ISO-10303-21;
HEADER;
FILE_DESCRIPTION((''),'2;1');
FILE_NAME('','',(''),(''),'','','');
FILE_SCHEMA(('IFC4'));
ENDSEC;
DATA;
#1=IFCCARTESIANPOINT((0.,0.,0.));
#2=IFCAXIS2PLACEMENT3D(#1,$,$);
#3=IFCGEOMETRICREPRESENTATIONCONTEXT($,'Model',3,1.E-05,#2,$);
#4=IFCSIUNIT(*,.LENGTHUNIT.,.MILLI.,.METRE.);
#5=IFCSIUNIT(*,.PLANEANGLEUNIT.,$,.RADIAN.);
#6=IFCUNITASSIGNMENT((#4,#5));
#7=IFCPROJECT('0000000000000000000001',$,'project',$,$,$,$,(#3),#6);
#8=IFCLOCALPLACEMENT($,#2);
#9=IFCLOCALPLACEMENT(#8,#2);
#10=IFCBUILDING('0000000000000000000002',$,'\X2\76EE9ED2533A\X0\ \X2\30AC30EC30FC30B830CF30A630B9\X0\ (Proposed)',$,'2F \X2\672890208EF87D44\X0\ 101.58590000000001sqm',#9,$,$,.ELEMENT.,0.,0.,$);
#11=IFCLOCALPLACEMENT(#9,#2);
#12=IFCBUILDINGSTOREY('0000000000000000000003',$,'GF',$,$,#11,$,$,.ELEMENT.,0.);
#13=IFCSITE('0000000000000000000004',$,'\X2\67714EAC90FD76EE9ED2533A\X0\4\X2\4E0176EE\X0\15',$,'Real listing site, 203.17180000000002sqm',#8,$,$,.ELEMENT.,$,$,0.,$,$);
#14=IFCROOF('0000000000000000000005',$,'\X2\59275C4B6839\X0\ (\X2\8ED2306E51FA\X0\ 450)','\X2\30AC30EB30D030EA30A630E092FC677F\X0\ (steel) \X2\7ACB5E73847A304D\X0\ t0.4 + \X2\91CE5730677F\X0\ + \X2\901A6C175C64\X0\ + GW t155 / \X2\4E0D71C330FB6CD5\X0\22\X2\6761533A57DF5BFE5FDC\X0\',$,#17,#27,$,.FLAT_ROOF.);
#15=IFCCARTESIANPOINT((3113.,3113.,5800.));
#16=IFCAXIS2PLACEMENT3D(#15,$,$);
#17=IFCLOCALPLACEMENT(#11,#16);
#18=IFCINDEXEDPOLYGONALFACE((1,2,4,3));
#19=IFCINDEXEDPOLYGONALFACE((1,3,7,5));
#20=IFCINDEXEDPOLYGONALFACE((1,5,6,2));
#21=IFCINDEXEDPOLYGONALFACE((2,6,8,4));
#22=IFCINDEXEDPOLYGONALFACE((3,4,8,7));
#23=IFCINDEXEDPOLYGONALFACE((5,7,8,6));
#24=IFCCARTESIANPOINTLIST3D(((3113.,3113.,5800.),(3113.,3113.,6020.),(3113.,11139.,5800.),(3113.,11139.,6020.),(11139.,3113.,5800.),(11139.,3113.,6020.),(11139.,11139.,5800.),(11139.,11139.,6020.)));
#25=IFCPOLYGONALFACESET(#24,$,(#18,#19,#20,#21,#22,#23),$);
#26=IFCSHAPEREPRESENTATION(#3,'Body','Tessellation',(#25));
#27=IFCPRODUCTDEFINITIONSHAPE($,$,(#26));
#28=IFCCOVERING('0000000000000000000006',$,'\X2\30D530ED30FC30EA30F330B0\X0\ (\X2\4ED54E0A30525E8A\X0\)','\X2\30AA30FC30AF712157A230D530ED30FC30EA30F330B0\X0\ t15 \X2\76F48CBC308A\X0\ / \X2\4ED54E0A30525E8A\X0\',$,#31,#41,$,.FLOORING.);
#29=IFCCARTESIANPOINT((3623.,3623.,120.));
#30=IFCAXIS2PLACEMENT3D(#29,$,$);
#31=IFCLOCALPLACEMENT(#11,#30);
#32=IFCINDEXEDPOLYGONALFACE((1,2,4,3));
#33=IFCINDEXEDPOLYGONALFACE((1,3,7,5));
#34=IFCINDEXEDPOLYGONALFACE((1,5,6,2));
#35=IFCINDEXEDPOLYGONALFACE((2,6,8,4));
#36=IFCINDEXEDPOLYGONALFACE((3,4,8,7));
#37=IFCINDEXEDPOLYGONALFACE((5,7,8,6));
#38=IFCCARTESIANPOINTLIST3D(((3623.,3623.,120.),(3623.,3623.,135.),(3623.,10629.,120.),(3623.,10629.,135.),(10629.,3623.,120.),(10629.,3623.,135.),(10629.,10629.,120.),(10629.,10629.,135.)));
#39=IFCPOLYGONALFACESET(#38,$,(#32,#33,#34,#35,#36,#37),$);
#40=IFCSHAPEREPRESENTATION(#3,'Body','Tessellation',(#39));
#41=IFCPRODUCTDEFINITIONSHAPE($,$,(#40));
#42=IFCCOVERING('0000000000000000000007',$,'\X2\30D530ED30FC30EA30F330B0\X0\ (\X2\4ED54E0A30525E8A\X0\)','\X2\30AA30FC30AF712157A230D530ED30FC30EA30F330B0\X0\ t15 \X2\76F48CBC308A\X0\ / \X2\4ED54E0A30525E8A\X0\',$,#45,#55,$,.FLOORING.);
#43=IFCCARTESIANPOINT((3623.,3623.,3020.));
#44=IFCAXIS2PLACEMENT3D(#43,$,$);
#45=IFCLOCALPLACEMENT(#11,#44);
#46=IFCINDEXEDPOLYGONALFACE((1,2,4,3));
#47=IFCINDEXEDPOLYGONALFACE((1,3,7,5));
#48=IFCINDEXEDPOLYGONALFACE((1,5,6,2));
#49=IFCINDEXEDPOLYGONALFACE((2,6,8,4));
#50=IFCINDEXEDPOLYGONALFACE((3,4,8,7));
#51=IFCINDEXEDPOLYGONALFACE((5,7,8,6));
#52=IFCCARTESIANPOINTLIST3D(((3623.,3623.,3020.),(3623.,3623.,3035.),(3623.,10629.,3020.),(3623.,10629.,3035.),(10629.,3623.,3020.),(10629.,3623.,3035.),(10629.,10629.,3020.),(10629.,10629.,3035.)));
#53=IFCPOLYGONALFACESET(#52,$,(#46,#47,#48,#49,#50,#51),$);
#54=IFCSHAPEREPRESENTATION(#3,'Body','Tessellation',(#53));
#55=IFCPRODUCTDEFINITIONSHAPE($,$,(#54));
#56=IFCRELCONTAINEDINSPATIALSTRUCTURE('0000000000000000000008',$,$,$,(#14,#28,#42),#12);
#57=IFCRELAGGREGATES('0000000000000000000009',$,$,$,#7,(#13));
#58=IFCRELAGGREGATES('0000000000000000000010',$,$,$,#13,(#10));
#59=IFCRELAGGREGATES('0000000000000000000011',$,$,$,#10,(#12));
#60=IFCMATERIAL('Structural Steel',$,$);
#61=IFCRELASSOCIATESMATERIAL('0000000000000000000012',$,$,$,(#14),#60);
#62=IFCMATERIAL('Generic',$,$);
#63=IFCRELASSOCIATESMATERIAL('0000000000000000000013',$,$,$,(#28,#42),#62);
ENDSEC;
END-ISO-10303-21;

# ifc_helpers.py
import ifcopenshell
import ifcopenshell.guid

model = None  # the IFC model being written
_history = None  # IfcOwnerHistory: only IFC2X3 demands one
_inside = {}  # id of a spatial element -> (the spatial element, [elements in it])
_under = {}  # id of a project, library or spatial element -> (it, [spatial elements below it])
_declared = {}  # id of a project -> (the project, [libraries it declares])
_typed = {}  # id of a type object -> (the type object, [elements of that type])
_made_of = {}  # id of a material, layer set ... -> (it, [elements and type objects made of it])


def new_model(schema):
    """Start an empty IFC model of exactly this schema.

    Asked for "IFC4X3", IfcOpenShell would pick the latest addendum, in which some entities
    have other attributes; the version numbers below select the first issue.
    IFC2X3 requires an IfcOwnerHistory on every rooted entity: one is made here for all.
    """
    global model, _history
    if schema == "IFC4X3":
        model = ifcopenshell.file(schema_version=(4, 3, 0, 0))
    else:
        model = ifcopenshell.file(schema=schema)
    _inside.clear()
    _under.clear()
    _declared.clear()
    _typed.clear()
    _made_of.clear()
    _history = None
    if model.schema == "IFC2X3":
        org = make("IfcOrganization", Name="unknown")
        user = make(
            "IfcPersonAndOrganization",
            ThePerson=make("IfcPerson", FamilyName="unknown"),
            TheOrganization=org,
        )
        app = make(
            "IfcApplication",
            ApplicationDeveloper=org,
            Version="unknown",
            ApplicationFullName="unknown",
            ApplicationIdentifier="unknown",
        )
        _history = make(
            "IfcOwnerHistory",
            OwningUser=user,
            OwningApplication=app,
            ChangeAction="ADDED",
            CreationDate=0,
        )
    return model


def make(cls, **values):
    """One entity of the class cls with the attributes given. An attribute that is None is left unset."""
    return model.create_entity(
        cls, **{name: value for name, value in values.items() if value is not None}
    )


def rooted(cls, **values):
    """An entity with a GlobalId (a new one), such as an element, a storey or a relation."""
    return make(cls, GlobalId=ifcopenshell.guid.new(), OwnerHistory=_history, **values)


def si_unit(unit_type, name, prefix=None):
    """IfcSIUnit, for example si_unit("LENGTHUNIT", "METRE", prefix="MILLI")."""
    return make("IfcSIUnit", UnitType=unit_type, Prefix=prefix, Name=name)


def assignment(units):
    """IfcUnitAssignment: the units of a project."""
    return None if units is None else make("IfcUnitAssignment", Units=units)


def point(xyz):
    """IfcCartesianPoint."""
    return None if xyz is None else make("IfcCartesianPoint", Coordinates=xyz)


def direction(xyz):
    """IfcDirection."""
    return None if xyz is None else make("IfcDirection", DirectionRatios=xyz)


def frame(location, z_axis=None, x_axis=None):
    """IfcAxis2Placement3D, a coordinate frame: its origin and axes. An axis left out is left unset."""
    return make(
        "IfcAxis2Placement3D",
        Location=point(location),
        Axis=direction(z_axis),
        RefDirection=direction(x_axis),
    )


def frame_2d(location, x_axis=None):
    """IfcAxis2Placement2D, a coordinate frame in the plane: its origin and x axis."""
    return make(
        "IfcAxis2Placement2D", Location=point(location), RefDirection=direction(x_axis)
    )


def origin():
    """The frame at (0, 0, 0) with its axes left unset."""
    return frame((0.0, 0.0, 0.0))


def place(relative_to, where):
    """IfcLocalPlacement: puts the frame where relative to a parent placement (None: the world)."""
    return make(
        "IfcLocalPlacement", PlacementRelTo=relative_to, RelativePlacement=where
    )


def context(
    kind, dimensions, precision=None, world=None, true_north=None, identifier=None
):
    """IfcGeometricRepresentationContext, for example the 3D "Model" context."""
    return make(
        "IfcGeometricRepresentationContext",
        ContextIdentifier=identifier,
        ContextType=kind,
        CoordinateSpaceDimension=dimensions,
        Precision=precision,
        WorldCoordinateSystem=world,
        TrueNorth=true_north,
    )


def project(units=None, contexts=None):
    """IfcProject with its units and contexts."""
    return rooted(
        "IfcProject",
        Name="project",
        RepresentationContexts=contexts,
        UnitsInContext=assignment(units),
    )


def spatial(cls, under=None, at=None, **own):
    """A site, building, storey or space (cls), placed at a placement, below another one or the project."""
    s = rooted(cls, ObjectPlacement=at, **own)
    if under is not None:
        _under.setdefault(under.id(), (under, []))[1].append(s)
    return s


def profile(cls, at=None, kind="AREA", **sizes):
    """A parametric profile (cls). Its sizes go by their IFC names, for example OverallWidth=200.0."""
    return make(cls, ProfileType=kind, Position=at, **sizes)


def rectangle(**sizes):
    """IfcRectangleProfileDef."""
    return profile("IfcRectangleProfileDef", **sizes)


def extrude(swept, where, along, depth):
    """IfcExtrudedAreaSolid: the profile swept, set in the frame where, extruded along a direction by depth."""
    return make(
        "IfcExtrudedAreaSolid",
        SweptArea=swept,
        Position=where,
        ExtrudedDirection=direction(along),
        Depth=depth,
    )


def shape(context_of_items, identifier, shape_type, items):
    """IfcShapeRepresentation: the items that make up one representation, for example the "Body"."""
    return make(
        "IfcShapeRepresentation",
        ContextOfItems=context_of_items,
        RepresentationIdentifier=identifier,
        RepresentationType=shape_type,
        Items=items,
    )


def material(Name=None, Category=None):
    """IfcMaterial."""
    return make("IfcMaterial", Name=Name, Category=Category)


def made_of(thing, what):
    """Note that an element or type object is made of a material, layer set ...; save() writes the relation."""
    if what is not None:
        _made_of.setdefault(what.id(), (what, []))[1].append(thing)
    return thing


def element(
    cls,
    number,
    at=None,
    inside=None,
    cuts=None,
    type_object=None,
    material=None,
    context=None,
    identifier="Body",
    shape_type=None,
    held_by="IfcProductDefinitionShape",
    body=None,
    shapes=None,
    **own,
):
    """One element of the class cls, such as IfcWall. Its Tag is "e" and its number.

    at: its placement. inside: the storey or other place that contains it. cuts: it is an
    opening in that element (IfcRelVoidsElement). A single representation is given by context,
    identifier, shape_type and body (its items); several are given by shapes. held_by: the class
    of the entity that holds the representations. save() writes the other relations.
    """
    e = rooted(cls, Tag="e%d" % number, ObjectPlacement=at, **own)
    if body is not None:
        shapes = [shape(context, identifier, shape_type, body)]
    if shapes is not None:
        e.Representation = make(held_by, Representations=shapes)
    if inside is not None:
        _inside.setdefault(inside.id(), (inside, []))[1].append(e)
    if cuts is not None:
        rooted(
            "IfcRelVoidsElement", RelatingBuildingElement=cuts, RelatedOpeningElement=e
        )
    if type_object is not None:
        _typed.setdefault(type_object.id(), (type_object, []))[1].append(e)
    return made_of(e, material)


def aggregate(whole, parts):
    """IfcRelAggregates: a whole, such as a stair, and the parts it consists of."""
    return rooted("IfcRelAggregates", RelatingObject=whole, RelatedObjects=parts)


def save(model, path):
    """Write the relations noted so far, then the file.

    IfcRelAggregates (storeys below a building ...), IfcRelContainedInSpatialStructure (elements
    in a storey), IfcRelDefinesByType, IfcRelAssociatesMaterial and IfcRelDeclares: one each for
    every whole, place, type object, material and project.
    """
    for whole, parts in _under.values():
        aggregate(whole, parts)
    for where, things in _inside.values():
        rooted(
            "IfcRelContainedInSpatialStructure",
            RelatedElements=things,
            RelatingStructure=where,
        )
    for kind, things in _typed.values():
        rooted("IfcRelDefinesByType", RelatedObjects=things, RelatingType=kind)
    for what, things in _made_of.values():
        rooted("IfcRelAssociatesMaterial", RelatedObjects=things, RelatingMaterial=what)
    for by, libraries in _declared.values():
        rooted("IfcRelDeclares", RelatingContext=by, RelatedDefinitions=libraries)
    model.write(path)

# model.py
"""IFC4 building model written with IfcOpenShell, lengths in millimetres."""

from ifc_helpers import new_model, si_unit, frame, frame_2d, origin, place, context, project, spatial, rectangle, extrude, material, element, save


model = new_model("IFC4")

# Units and contexts
model_context = context("Model", 3, precision=1e-05, world=origin())
ifc_project = project(units=[si_unit("LENGTHUNIT", "METRE", prefix="MILLI"), si_unit("PLANEANGLEUNIT", "RADIAN")], contexts=[model_context])

# Site, building, storey
site_placement = place(None, origin())
site = spatial("IfcSite", under=ifc_project, at=site_placement, Name="東京都目黒区4丁目15", ObjectType="Real listing site, 203.17180000000002sqm", CompositionType="ELEMENT", RefElevation=0.0)
building_placement = place(site_placement, origin())
building = spatial("IfcBuilding", under=site, at=building_placement, Name="目黒区 ガレージハウス (Proposed)", ObjectType="2F 木造軸組 101.58590000000001sqm", CompositionType="ELEMENT", ElevationOfRefHeight=0.0, ElevationOfTerrain=0.0)
storey_placement = place(building_placement, origin())
storey = spatial("IfcBuildingStorey", under=building, at=storey_placement, Name="GF", CompositionType="ELEMENT", Elevation=0.0)

# Roof
ifc_material_1 = material(Name="Structural Steel")
roof_placement = place(storey_placement, frame((3113.0, 3113.0, 5800.0)))
element("IfcRoof", 1, at=roof_placement, inside=storey, material=ifc_material_1, Name="大屋根 (軒の出 450)", Description="ガルバリウム鋼板 (steel) 立平葺き t0.4 + 野地板 + 通気層 + GW t155 / 不燃・法22条区域対応", PredefinedType="FLAT_ROOF", context=model_context, shape_type="SweptSolid", body=[
    extrude(rectangle(XDim=8026.0, YDim=8026.0, at=frame_2d((4013.0, 4013.0))), frame((3113.0, 3113.0, 5800.0)), (0.0, 0.0, 1.0), 220.0),
])

# Coverings
ifc_material_2 = material(Name="Generic")
covering_1_placement = place(storey_placement, frame((3623.0, 3623.0, 120.0)))
element("IfcCovering", 2, at=covering_1_placement, inside=storey, material=ifc_material_2, Name="フローリング (仕上げ床)", Description="オーク無垢フローリング t15 直貼り / 仕上げ床", PredefinedType="FLOORING", context=model_context, shape_type="SweptSolid", body=[
    extrude(rectangle(XDim=7006.0, YDim=7006.0, at=frame_2d((3503.0, 3503.0))), frame((3623.0, 3623.0, 120.0)), (0.0, 0.0, 1.0), 15.0),
])
covering_2_placement = place(storey_placement, frame((3623.0, 3623.0, 3020.0)))
element("IfcCovering", 3, at=covering_2_placement, inside=storey, material=ifc_material_2, Name="フローリング (仕上げ床)", Description="オーク無垢フローリング t15 直貼り / 仕上げ床", PredefinedType="FLOORING", context=model_context, shape_type="SweptSolid", body=[
    extrude(rectangle(XDim=7006.0, YDim=7006.0, at=frame_2d((3503.0, 3503.0))), frame((3623.0, 3623.0, 3020.0)), (0.0, 0.0, 1.0), 15.0),
])

save(model, "model.ifc")
